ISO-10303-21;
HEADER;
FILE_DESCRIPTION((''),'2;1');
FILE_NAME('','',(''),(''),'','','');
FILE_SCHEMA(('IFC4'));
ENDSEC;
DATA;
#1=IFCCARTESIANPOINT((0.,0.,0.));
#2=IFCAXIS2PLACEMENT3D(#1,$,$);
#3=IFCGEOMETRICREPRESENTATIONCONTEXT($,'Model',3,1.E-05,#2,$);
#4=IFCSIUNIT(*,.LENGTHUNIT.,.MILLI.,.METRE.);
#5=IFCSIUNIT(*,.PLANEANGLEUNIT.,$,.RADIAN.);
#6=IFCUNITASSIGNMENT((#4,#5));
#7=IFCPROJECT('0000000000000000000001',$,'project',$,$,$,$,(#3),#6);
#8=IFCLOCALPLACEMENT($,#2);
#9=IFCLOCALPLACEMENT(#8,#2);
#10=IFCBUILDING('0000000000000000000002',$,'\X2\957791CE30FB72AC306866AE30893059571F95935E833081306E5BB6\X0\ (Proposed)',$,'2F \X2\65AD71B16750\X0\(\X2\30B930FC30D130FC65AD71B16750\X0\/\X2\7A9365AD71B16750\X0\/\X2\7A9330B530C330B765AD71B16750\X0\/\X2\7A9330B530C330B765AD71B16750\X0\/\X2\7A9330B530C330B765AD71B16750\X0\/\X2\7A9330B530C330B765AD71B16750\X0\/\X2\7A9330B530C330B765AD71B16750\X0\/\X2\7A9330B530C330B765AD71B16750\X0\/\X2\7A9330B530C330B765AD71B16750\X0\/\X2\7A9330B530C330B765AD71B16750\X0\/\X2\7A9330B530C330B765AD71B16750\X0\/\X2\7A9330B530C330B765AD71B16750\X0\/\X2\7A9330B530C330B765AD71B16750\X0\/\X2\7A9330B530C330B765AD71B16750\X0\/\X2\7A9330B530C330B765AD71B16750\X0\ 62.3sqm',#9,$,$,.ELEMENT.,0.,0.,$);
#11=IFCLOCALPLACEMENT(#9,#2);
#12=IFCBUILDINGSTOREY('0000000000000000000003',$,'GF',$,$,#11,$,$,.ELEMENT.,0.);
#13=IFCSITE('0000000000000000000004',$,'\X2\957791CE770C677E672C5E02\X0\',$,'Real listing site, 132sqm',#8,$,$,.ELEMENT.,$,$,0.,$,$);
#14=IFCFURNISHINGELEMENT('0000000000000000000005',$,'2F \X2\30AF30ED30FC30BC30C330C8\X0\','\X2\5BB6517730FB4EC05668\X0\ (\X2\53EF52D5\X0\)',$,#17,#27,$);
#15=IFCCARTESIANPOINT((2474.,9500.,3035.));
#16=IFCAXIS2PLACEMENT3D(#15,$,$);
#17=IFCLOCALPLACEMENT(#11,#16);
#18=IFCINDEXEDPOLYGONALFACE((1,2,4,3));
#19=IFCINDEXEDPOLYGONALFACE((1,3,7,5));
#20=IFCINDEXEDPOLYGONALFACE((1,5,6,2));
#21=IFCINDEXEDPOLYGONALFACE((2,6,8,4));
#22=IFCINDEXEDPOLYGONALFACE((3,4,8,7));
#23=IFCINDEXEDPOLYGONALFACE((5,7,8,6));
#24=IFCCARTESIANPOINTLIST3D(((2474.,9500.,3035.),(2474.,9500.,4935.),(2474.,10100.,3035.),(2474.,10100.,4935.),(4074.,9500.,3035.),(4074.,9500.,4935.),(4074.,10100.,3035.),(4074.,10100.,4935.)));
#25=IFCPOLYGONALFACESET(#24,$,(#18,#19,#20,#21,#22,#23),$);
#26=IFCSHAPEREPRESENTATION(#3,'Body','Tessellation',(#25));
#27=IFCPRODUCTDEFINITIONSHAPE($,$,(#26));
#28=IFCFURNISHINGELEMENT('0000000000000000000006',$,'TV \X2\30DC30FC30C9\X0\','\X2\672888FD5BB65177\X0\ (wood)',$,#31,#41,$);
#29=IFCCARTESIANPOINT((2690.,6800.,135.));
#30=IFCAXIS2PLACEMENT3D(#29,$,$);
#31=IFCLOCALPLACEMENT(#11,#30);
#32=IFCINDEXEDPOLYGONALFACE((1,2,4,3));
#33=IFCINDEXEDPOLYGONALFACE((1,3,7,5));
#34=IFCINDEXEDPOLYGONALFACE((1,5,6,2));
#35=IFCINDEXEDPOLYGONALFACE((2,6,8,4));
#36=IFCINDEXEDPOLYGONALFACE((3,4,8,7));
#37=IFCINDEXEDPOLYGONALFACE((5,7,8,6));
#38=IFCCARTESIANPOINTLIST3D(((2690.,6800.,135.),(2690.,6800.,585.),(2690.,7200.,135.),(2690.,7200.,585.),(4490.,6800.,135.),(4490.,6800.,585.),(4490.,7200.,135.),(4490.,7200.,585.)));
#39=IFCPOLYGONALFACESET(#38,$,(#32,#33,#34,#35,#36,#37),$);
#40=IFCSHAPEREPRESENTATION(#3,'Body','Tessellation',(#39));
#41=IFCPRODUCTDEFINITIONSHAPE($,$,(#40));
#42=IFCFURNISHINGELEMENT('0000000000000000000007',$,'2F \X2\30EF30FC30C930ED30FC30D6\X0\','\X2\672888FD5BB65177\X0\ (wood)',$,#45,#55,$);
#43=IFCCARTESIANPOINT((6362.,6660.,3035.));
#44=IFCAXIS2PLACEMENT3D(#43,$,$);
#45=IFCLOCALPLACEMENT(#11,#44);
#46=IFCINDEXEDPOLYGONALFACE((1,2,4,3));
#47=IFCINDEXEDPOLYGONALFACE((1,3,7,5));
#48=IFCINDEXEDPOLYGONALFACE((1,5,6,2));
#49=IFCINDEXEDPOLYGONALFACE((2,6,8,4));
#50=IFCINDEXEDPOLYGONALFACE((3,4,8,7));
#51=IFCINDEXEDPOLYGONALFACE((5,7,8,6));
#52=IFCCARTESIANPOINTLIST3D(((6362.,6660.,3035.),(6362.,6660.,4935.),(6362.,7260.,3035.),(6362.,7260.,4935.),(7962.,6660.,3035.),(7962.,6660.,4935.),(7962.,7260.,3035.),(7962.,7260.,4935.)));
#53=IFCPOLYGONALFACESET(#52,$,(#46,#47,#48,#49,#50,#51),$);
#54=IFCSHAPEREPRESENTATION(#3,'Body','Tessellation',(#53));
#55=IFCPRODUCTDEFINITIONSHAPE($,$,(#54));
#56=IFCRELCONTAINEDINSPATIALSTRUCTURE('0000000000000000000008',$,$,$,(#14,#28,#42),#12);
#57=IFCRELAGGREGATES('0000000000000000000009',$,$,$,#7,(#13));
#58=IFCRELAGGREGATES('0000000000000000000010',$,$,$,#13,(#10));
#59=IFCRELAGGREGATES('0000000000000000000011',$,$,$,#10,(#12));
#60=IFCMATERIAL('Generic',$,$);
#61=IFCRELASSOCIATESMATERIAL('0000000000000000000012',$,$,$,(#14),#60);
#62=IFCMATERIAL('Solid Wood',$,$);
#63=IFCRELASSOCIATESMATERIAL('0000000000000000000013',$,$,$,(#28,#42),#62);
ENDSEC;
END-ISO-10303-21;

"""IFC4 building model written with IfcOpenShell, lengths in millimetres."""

from ifc_helpers import new_model, si_unit, frame, frame_2d, origin, place, context, project, spatial, rectangle, extrude, material, element, save


model = new_model("IFC4")

# Units and contexts
model_context = context("Model", 3, precision=1e-05, world=origin())
ifc_project = project(units=[si_unit("LENGTHUNIT", "METRE", prefix="MILLI"), si_unit("PLANEANGLEUNIT", "RADIAN")], contexts=[model_context])

# Site, building, storey
site_placement = place(None, origin())
site = spatial("IfcSite", under=ifc_project, at=site_placement, Name="長野県松本市", ObjectType="Real listing site, 132sqm", CompositionType="ELEMENT", RefElevation=0.0)
building_placement = place(site_placement, origin())
building = spatial("IfcBuilding", under=site, at=building_placement, Name="長野・犬と暮らす土間広めの家 (Proposed)", ObjectType="2F 断熱材(スーパー断熱材/窓断熱材/窓サッシ断熱材/窓サッシ断熱材/窓サッシ断熱材/窓サッシ断熱材/窓サッシ断熱材/窓サッシ断熱材/窓サッシ断熱材/窓サッシ断熱材/窓サッシ断熱材/窓サッシ断熱材/窓サッシ断熱材/窓サッシ断熱材/窓サッシ断熱材 62.3sqm", CompositionType="ELEMENT", ElevationOfRefHeight=0.0, ElevationOfTerrain=0.0)
storey_placement = place(building_placement, origin())
storey = spatial("IfcBuildingStorey", under=building, at=storey_placement, Name="GF", CompositionType="ELEMENT", Elevation=0.0)

# Shared definitions
ifc_material_1 = material(Name="Solid Wood")

# Shared definitions
ifc_material_2 = material(Name="Generic")

# Furnishing elements
furnishing_1_placement = place(storey_placement, frame((2474.0, 9500.0, 3035.0)))
element("IfcFurnishingElement", 1, at=furnishing_1_placement, inside=storey, material=ifc_material_2, Name="2F クローゼット", Description="家具・什器 (可動)", context=model_context, shape_type="SweptSolid", body=[
    extrude(rectangle(XDim=1600.0, YDim=600.0, at=frame_2d((800.0, 300.0))), frame((2474.0, 9500.0, 3035.0)), (0.0, 0.0, 1.0), 1900.0),
])
furnishing_2_placement = place(storey_placement, frame((2690.0, 6800.0, 135.0)))
element("IfcFurnishingElement", 2, at=furnishing_2_placement, inside=storey, material=ifc_material_1, Name="TV ボード", Description="木製家具 (wood)", context=model_context, shape_type="SweptSolid", body=[
    extrude(rectangle(XDim=1800.0, YDim=400.0, at=frame_2d((900.0, 200.0))), frame((2690.0, 6800.0, 135.0)), (0.0, 0.0, 1.0), 450.0),
])
furnishing_3_placement = place(storey_placement, frame((6362.0, 6660.0, 3035.0)))
element("IfcFurnishingElement", 3, at=furnishing_3_placement, inside=storey, material=ifc_material_1, Name="2F ワードローブ", Description="木製家具 (wood)", context=model_context, shape_type="SweptSolid", body=[
    extrude(rectangle(XDim=1600.0, YDim=600.0, at=frame_2d((800.0, 300.0))), frame((6362.0, 6660.0, 3035.0)), (0.0, 0.0, 1.0), 1900.0),
])

save(model, "model.ifc")
